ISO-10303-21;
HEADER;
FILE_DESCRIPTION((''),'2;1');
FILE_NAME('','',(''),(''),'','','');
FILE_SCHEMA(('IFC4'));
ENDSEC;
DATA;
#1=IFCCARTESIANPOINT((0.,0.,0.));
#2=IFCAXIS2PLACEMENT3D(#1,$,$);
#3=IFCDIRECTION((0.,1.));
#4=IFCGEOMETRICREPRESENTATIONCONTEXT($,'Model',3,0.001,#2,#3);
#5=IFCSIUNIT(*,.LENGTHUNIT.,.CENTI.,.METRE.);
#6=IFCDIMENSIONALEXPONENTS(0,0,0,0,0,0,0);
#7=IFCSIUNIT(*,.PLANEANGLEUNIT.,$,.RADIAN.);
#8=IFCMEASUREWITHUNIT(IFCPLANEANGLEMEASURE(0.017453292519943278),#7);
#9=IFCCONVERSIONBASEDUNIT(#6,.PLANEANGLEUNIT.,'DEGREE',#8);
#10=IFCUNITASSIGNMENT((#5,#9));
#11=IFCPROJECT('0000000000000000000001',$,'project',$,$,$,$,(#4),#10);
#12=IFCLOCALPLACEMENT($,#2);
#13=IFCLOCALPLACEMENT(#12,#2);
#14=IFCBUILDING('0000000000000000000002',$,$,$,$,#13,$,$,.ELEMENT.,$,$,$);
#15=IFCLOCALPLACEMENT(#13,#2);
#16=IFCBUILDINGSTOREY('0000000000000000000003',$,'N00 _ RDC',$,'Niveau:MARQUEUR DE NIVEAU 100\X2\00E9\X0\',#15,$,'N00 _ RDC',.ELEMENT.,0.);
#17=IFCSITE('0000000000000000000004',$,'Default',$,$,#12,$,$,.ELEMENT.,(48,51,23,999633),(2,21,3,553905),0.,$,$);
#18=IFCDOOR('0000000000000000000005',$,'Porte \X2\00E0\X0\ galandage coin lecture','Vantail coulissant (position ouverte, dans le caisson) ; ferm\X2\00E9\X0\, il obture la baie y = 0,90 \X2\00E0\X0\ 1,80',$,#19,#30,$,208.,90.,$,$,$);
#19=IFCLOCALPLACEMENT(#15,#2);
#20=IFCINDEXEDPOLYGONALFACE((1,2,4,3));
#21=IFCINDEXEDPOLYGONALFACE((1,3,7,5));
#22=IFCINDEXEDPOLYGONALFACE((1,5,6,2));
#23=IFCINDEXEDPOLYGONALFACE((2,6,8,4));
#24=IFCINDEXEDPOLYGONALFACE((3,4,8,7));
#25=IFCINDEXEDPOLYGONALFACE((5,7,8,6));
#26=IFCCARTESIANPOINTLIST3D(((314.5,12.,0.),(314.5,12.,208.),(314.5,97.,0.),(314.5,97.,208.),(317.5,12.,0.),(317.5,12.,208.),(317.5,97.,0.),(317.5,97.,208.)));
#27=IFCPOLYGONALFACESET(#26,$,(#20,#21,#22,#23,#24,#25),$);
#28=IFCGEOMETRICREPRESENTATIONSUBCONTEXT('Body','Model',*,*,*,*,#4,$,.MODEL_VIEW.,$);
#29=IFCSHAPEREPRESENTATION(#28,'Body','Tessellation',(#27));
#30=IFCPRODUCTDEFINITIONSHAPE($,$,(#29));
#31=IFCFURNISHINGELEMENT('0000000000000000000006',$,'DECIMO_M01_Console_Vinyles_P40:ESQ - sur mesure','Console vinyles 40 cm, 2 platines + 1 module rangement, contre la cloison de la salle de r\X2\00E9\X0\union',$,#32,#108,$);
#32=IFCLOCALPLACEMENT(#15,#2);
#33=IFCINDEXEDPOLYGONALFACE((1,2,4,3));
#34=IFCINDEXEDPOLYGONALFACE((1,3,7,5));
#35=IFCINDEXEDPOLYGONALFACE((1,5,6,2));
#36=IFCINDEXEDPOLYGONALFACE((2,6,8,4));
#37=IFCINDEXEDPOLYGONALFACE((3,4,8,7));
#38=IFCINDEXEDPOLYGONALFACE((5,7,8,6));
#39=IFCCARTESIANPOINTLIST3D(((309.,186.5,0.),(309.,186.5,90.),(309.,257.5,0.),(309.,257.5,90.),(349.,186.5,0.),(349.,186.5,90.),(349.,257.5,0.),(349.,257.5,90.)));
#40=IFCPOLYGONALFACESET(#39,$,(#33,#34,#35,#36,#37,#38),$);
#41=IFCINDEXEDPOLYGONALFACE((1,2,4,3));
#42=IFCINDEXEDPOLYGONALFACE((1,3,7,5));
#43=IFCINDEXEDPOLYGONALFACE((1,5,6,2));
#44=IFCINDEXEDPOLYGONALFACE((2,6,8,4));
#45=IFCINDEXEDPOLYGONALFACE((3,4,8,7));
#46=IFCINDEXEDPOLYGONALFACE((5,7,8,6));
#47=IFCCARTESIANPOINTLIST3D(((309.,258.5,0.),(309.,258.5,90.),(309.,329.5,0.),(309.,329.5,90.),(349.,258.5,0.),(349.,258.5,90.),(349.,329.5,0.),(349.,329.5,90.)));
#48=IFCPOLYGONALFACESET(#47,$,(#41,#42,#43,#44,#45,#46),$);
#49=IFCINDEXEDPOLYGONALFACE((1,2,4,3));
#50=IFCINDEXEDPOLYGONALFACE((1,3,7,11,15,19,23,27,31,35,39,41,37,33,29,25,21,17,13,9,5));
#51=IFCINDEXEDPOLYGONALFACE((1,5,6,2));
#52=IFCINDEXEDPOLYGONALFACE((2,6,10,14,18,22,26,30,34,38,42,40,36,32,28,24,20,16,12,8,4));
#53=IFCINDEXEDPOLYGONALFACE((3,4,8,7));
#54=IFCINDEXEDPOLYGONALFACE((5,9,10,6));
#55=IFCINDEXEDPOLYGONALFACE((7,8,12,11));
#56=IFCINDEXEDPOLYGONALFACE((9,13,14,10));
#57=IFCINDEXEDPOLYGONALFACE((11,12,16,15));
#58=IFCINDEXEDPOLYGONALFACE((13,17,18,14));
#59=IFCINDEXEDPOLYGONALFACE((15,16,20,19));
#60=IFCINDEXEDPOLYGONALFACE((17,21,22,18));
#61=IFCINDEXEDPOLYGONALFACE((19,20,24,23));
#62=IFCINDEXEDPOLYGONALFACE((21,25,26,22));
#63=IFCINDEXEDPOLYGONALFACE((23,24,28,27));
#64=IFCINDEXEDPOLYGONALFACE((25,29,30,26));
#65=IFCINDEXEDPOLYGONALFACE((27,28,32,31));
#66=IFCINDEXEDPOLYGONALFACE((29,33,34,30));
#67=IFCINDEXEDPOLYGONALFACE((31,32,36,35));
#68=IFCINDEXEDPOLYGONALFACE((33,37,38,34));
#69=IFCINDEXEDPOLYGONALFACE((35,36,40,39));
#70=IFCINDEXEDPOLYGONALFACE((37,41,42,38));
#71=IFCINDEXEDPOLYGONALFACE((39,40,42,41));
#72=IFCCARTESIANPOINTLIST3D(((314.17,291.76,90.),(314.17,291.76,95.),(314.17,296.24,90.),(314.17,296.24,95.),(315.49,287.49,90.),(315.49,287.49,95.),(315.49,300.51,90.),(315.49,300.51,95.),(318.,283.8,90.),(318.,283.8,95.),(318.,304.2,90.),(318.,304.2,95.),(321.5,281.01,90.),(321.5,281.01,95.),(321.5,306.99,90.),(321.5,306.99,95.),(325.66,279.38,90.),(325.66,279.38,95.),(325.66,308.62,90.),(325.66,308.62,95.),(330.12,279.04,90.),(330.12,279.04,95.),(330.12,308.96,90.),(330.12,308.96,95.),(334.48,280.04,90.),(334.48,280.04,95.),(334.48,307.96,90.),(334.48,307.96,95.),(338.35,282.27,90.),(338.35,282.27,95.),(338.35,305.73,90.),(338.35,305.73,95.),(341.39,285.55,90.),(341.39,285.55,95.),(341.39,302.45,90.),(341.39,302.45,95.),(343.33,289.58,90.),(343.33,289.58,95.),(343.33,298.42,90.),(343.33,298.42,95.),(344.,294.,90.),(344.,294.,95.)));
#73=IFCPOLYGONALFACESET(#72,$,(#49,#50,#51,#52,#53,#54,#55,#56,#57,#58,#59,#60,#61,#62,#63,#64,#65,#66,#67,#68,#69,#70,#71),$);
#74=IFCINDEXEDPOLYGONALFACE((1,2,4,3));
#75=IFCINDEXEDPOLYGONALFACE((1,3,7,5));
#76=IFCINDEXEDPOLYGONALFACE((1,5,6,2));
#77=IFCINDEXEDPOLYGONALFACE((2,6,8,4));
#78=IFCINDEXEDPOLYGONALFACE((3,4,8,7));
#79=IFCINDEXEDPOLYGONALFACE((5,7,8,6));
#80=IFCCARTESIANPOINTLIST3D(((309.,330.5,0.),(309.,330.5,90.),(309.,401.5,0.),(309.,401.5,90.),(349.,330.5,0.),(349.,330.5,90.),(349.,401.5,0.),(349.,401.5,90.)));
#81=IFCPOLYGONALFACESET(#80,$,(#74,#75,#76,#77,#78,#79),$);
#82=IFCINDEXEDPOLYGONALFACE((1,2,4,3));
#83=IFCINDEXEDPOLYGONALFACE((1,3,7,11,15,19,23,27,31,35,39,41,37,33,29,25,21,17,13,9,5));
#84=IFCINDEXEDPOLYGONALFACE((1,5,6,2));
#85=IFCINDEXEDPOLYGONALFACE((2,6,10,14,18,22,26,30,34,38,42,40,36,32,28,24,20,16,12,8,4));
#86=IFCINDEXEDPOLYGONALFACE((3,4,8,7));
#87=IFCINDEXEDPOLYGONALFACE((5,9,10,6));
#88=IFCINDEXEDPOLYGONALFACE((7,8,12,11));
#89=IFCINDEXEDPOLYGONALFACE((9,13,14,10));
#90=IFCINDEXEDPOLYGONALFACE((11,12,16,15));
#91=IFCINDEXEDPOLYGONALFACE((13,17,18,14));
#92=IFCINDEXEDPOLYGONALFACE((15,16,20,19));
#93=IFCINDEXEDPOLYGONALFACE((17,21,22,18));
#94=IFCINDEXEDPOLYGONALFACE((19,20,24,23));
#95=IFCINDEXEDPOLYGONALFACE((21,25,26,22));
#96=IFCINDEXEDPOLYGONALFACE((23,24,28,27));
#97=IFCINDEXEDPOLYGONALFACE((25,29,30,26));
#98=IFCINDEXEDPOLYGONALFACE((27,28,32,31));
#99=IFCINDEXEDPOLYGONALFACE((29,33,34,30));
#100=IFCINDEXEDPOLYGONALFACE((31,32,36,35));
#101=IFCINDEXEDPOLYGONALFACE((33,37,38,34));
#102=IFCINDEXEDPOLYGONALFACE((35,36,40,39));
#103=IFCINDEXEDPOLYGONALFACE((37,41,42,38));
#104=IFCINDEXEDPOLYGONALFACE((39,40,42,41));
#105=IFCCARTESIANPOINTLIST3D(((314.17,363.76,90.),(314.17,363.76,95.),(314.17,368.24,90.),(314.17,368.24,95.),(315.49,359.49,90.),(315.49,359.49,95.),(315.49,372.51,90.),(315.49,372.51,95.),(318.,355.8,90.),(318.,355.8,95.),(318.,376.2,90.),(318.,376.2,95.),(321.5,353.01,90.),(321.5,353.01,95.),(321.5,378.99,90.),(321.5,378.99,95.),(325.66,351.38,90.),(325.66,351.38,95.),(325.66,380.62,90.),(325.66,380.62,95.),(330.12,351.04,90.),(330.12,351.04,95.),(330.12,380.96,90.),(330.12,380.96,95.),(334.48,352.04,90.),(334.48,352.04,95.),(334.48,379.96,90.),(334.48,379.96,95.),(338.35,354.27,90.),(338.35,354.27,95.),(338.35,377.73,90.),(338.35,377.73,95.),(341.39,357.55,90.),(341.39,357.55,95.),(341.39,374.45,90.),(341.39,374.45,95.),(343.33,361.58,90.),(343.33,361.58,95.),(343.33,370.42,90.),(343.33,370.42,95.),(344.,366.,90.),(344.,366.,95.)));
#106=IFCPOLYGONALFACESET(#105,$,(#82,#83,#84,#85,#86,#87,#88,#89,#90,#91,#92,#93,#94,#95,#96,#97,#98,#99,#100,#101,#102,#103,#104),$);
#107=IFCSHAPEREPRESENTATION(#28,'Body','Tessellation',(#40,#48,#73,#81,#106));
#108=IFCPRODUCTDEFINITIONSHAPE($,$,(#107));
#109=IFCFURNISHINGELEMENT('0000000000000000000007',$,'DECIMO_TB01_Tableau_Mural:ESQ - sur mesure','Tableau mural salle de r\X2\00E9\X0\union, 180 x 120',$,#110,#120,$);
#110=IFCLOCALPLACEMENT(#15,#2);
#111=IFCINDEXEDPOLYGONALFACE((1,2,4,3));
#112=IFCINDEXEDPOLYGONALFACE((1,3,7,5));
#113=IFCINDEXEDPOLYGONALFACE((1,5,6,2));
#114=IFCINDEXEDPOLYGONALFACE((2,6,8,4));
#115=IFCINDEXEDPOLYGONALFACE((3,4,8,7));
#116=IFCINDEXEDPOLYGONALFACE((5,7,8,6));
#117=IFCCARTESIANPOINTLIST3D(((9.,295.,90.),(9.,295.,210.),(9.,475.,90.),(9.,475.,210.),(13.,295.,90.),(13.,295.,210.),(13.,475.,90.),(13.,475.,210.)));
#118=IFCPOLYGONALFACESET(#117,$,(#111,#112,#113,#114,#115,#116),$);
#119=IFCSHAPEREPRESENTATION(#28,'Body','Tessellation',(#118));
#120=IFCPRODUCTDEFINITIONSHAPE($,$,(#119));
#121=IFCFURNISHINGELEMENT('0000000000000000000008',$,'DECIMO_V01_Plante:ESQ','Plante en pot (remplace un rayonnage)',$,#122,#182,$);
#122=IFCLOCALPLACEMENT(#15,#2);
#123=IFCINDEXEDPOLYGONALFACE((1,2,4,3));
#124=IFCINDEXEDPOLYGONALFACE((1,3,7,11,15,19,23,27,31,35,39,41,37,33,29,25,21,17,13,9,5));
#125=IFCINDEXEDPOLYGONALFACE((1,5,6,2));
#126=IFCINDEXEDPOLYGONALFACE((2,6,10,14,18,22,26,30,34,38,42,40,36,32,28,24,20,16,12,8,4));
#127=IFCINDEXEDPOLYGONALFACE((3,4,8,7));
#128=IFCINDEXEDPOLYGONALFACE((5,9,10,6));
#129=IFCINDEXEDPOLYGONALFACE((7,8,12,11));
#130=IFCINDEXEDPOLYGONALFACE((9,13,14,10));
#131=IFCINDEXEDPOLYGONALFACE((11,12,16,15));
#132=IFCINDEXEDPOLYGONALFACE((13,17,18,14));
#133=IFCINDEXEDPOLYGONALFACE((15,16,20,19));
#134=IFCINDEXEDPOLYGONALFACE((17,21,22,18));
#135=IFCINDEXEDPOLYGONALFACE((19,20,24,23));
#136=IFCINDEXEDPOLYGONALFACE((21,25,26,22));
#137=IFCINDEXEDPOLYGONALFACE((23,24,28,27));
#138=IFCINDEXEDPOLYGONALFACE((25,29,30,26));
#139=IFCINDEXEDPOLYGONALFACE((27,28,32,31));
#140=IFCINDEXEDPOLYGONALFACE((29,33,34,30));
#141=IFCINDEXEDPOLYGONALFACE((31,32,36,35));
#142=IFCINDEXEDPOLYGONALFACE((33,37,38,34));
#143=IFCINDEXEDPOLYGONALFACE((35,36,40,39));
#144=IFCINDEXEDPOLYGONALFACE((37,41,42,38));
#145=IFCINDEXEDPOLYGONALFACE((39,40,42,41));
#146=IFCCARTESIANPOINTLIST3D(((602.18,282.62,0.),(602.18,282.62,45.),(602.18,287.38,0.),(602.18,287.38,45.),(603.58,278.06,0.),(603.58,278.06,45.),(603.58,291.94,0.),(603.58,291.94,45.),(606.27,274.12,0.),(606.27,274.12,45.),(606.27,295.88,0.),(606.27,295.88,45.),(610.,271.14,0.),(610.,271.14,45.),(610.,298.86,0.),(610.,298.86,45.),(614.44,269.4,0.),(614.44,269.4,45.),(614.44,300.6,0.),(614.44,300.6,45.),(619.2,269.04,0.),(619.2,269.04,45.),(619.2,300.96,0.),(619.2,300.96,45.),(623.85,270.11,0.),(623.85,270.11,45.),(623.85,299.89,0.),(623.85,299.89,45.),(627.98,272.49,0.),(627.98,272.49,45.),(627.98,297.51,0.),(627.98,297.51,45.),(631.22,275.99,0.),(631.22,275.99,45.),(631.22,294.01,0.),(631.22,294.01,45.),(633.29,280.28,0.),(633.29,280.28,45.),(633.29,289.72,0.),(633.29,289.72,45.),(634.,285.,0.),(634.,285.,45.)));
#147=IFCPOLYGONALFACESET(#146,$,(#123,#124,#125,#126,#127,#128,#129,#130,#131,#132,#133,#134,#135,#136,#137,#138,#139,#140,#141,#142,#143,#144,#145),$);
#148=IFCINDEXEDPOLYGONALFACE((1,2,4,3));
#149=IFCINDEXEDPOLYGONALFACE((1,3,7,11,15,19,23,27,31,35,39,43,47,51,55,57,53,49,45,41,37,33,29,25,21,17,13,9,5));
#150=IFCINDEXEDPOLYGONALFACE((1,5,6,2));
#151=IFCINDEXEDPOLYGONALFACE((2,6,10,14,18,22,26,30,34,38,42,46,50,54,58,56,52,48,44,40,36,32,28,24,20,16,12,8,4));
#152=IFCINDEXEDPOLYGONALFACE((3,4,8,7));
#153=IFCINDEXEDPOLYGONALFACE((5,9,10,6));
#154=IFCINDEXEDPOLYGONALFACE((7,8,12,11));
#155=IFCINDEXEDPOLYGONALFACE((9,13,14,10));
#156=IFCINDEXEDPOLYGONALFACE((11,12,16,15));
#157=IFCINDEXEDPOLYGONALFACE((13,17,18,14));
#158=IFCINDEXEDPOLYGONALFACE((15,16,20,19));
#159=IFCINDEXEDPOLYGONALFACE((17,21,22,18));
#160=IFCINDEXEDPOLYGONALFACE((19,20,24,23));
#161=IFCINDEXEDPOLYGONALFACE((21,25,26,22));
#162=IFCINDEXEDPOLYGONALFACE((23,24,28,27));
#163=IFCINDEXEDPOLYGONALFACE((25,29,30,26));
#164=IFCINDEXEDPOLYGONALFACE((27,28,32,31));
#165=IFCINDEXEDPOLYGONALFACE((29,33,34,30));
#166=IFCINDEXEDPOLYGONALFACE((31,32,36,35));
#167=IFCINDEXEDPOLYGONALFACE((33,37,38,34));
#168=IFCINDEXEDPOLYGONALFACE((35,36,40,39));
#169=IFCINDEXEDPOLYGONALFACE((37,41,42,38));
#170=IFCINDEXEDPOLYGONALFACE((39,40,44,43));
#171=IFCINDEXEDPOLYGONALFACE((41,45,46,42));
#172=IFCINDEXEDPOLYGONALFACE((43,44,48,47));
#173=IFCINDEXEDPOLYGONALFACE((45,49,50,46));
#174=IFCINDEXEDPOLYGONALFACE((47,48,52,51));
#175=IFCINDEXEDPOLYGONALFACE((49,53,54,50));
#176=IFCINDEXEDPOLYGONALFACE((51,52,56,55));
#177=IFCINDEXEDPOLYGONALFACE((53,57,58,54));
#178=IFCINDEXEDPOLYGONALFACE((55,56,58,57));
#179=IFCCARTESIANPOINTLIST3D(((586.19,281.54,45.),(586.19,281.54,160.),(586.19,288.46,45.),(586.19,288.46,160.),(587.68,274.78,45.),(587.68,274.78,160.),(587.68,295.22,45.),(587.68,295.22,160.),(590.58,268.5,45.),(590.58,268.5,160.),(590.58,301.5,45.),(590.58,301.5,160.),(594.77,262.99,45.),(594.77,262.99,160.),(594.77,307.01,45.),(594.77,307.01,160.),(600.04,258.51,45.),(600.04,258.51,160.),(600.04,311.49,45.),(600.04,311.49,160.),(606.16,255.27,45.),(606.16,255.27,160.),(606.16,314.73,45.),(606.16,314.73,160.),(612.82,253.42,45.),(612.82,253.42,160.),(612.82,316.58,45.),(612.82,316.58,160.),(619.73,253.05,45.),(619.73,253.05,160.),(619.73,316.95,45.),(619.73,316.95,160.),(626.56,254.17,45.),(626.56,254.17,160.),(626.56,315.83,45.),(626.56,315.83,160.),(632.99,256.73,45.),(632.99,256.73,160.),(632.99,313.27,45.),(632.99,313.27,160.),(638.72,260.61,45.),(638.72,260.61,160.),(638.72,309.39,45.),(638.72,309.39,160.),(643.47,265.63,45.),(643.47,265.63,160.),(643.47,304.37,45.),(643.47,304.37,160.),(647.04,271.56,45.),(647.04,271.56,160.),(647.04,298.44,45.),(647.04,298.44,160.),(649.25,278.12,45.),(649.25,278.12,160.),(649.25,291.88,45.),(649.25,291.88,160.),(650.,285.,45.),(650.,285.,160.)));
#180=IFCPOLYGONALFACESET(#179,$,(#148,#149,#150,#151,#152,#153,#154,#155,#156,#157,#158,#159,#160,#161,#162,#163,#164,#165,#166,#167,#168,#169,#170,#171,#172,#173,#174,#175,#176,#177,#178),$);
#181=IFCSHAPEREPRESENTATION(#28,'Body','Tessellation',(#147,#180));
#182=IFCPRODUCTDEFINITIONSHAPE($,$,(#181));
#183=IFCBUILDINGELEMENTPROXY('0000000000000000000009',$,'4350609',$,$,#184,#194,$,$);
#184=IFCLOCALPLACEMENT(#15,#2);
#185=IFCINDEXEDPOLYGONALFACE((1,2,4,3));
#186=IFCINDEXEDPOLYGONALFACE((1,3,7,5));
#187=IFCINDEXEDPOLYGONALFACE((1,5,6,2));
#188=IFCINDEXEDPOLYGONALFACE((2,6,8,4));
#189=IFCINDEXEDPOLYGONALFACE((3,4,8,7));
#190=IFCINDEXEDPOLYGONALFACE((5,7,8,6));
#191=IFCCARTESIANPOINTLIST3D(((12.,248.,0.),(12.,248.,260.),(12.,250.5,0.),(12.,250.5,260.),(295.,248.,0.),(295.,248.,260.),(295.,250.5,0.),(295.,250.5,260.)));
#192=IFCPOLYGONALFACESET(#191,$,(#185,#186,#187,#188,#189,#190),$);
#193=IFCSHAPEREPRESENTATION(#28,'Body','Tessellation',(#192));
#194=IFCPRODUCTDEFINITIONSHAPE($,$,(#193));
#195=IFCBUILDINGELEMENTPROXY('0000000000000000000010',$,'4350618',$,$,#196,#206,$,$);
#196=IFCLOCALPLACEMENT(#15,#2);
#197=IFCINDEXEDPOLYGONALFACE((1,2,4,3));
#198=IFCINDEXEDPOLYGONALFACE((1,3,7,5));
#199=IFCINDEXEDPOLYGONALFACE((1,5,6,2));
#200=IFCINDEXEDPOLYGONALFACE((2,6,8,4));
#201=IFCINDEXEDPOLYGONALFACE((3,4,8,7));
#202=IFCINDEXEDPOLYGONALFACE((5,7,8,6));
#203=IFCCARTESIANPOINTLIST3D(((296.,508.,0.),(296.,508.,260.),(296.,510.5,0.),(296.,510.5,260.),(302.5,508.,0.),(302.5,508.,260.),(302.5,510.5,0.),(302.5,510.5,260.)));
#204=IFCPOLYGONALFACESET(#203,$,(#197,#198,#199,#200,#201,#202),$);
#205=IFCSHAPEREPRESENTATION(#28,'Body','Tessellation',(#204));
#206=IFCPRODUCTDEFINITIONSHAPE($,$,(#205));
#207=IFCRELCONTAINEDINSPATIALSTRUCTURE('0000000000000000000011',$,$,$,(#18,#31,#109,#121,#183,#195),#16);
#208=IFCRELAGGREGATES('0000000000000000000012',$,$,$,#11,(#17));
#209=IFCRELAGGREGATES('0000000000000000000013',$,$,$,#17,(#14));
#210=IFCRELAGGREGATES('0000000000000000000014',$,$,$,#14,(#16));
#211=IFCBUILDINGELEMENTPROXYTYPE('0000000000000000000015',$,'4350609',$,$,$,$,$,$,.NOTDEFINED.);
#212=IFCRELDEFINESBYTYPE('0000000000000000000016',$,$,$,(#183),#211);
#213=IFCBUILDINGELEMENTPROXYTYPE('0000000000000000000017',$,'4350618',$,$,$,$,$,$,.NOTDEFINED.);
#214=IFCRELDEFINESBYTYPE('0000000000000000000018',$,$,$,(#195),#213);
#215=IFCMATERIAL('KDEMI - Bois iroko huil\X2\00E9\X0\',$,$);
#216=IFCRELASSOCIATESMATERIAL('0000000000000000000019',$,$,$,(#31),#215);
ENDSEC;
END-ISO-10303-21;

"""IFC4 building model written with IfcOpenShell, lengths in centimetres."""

from ifc_helpers import new_model, entity, si_unit, converted_unit, direction, frame, frame_2d, origin, origin_with_axes, place, context, subcontext, project, spatial, rectangle, circle, extrude, material, type_object, element, save


model = new_model("IFC4")

# Units and contexts
model_context = context("Model", 3, precision=0.001, world=origin(), true_north=direction((0.0, 1.0)))
body_context = subcontext(model_context, "Body", "Model", "MODEL_VIEW")
ifc_project = project(units=[si_unit("LENGTHUNIT", "METRE", prefix="CENTI"), converted_unit("PLANEANGLEUNIT", "DEGREE", entity("IfcPlaneAngleMeasure", 0.017453292519943278), si_unit("PLANEANGLEUNIT", "RADIAN"), dimensions=[0, 0, 0, 0, 0, 0, 0])], contexts=[model_context])

# Site, building, storey
site_placement = place(None, origin())
site = spatial("IfcSite", under=ifc_project, at=site_placement, Name="Default", CompositionType="ELEMENT", RefLatitude=(48, 51, 23, 999633), RefLongitude=(2, 21, 3, 553905), RefElevation=0.0)
building_placement = place(site_placement, origin())
building = spatial("IfcBuilding", under=site, at=building_placement, CompositionType="ELEMENT")
storey_placement = place(building_placement, origin())
storey = spatial("IfcBuildingStorey", under=building, at=storey_placement, Name="N00 _ RDC", ObjectType="Niveau:MARQUEUR DE NIVEAU 100é", LongName="N00 _ RDC", CompositionType="ELEMENT", Elevation=0.0)

# Door
door_placement = place(storey_placement, origin_with_axes())
element("IfcDoor", 1, at=door_placement, inside=storey, Name="Porte à galandage coin lecture", Description="Vantail coulissant (position ouverte, dans le caisson) ; fermé, il obture la baie y = 0,90 à 1,80", OverallHeight=208.0, OverallWidth=90.0, context=body_context, shape_type="SweptSolid", body=[
    extrude(rectangle(XDim=3.0, YDim=85.0, at=frame_2d((316.0, 54.5))), origin(), (0.0, 0.0, 1.0), 208.0),
])

# Furnishing elements
ifc_material_1 = material(Name="KDEMI - Bois iroko huilé")
furnishing_1_placement = place(storey_placement, origin_with_axes())
element("IfcFurnishingElement", 2, at=furnishing_1_placement, inside=storey, material=ifc_material_1, Name="DECIMO_M01_Console_Vinyles_P40:ESQ - sur mesure", Description="Console vinyles 40 cm, 2 platines + 1 module rangement, contre la cloison de la salle de réunion", context=body_context, shape_type="SweptSolid", body=[
    extrude(rectangle(XDim=40.0, YDim=71.0, at=frame_2d((329.0, 222.0))), origin(), (0.0, 0.0, 1.0), 90.0),
    extrude(rectangle(XDim=40.0, YDim=71.0, at=frame_2d((329.0, 294.0))), origin(), (0.0, 0.0, 1.0), 90.0),
    extrude(circle(Radius=15.0, at=frame_2d((329.0, 294.0))), frame((0.0, 0.0, 90.0)), (0.0, 0.0, 1.0), 5.0),
    extrude(rectangle(XDim=40.0, YDim=71.0, at=frame_2d((329.0, 366.0))), origin(), (0.0, 0.0, 1.0), 90.0),
    extrude(circle(Radius=15.0, at=frame_2d((329.0, 366.0))), frame((0.0, 0.0, 90.0)), (0.0, 0.0, 1.0), 5.0),
])
furnishing_2_placement = place(storey_placement, origin_with_axes())
element("IfcFurnishingElement", 3, at=furnishing_2_placement, inside=storey, Name="DECIMO_TB01_Tableau_Mural:ESQ - sur mesure", Description="Tableau mural salle de réunion, 180 x 120", context=body_context, shape_type="SweptSolid", body=[
    extrude(rectangle(XDim=4.0, YDim=180.0, at=frame_2d((11.0, 385.0))), frame((0.0, 0.0, 90.0)), (0.0, 0.0, 1.0), 120.0),
])
furnishing_3_placement = place(storey_placement, origin_with_axes())
element("IfcFurnishingElement", 4, at=furnishing_3_placement, inside=storey, Name="DECIMO_V01_Plante:ESQ", Description="Plante en pot (remplace un rayonnage)", context=body_context, shape_type="SweptSolid", body=[
    extrude(circle(Radius=16.0, at=frame_2d((618.0, 285.0))), origin(), (0.0, 0.0, 1.0), 45.0),
    extrude(circle(Radius=32.0, at=frame_2d((618.0, 285.0))), frame((0.0, 0.0, 45.0)), (0.0, 0.0, 1.0), 115.0),
])

# Building element proxies
building_element_proxy_type_1 = type_object("IfcBuildingElementProxyType", Name="4350609", PredefinedType="NOTDEFINED")
proxy_1_placement = place(storey_placement, origin())
element("IfcBuildingElementProxy", 5, at=proxy_1_placement, inside=storey, type_object=building_element_proxy_type_1, Name="4350609", context=body_context, shape_type="SweptSolid", body=[
    extrude(rectangle(XDim=283.0, YDim=2.5, at=frame_2d((0.0, 0.0), x_axis=(1.0, 0.0))), frame((153.5, 249.25, 0.0)), (0.0, 0.0, 1.0), 260.0),
])
building_element_proxy_type_2 = type_object("IfcBuildingElementProxyType", Name="4350618", PredefinedType="NOTDEFINED")
proxy_2_placement = place(storey_placement, origin())
element("IfcBuildingElementProxy", 6, at=proxy_2_placement, inside=storey, type_object=building_element_proxy_type_2, Name="4350618", context=body_context, shape_type="SweptSolid", body=[
    extrude(rectangle(XDim=6.5, YDim=2.5, at=frame_2d((0.0, 0.0), x_axis=(1.0, 0.0))), frame((299.25, 509.25, 0.0)), (0.0, 0.0, 1.0), 260.0),
])

save(model, "model.ifc")
